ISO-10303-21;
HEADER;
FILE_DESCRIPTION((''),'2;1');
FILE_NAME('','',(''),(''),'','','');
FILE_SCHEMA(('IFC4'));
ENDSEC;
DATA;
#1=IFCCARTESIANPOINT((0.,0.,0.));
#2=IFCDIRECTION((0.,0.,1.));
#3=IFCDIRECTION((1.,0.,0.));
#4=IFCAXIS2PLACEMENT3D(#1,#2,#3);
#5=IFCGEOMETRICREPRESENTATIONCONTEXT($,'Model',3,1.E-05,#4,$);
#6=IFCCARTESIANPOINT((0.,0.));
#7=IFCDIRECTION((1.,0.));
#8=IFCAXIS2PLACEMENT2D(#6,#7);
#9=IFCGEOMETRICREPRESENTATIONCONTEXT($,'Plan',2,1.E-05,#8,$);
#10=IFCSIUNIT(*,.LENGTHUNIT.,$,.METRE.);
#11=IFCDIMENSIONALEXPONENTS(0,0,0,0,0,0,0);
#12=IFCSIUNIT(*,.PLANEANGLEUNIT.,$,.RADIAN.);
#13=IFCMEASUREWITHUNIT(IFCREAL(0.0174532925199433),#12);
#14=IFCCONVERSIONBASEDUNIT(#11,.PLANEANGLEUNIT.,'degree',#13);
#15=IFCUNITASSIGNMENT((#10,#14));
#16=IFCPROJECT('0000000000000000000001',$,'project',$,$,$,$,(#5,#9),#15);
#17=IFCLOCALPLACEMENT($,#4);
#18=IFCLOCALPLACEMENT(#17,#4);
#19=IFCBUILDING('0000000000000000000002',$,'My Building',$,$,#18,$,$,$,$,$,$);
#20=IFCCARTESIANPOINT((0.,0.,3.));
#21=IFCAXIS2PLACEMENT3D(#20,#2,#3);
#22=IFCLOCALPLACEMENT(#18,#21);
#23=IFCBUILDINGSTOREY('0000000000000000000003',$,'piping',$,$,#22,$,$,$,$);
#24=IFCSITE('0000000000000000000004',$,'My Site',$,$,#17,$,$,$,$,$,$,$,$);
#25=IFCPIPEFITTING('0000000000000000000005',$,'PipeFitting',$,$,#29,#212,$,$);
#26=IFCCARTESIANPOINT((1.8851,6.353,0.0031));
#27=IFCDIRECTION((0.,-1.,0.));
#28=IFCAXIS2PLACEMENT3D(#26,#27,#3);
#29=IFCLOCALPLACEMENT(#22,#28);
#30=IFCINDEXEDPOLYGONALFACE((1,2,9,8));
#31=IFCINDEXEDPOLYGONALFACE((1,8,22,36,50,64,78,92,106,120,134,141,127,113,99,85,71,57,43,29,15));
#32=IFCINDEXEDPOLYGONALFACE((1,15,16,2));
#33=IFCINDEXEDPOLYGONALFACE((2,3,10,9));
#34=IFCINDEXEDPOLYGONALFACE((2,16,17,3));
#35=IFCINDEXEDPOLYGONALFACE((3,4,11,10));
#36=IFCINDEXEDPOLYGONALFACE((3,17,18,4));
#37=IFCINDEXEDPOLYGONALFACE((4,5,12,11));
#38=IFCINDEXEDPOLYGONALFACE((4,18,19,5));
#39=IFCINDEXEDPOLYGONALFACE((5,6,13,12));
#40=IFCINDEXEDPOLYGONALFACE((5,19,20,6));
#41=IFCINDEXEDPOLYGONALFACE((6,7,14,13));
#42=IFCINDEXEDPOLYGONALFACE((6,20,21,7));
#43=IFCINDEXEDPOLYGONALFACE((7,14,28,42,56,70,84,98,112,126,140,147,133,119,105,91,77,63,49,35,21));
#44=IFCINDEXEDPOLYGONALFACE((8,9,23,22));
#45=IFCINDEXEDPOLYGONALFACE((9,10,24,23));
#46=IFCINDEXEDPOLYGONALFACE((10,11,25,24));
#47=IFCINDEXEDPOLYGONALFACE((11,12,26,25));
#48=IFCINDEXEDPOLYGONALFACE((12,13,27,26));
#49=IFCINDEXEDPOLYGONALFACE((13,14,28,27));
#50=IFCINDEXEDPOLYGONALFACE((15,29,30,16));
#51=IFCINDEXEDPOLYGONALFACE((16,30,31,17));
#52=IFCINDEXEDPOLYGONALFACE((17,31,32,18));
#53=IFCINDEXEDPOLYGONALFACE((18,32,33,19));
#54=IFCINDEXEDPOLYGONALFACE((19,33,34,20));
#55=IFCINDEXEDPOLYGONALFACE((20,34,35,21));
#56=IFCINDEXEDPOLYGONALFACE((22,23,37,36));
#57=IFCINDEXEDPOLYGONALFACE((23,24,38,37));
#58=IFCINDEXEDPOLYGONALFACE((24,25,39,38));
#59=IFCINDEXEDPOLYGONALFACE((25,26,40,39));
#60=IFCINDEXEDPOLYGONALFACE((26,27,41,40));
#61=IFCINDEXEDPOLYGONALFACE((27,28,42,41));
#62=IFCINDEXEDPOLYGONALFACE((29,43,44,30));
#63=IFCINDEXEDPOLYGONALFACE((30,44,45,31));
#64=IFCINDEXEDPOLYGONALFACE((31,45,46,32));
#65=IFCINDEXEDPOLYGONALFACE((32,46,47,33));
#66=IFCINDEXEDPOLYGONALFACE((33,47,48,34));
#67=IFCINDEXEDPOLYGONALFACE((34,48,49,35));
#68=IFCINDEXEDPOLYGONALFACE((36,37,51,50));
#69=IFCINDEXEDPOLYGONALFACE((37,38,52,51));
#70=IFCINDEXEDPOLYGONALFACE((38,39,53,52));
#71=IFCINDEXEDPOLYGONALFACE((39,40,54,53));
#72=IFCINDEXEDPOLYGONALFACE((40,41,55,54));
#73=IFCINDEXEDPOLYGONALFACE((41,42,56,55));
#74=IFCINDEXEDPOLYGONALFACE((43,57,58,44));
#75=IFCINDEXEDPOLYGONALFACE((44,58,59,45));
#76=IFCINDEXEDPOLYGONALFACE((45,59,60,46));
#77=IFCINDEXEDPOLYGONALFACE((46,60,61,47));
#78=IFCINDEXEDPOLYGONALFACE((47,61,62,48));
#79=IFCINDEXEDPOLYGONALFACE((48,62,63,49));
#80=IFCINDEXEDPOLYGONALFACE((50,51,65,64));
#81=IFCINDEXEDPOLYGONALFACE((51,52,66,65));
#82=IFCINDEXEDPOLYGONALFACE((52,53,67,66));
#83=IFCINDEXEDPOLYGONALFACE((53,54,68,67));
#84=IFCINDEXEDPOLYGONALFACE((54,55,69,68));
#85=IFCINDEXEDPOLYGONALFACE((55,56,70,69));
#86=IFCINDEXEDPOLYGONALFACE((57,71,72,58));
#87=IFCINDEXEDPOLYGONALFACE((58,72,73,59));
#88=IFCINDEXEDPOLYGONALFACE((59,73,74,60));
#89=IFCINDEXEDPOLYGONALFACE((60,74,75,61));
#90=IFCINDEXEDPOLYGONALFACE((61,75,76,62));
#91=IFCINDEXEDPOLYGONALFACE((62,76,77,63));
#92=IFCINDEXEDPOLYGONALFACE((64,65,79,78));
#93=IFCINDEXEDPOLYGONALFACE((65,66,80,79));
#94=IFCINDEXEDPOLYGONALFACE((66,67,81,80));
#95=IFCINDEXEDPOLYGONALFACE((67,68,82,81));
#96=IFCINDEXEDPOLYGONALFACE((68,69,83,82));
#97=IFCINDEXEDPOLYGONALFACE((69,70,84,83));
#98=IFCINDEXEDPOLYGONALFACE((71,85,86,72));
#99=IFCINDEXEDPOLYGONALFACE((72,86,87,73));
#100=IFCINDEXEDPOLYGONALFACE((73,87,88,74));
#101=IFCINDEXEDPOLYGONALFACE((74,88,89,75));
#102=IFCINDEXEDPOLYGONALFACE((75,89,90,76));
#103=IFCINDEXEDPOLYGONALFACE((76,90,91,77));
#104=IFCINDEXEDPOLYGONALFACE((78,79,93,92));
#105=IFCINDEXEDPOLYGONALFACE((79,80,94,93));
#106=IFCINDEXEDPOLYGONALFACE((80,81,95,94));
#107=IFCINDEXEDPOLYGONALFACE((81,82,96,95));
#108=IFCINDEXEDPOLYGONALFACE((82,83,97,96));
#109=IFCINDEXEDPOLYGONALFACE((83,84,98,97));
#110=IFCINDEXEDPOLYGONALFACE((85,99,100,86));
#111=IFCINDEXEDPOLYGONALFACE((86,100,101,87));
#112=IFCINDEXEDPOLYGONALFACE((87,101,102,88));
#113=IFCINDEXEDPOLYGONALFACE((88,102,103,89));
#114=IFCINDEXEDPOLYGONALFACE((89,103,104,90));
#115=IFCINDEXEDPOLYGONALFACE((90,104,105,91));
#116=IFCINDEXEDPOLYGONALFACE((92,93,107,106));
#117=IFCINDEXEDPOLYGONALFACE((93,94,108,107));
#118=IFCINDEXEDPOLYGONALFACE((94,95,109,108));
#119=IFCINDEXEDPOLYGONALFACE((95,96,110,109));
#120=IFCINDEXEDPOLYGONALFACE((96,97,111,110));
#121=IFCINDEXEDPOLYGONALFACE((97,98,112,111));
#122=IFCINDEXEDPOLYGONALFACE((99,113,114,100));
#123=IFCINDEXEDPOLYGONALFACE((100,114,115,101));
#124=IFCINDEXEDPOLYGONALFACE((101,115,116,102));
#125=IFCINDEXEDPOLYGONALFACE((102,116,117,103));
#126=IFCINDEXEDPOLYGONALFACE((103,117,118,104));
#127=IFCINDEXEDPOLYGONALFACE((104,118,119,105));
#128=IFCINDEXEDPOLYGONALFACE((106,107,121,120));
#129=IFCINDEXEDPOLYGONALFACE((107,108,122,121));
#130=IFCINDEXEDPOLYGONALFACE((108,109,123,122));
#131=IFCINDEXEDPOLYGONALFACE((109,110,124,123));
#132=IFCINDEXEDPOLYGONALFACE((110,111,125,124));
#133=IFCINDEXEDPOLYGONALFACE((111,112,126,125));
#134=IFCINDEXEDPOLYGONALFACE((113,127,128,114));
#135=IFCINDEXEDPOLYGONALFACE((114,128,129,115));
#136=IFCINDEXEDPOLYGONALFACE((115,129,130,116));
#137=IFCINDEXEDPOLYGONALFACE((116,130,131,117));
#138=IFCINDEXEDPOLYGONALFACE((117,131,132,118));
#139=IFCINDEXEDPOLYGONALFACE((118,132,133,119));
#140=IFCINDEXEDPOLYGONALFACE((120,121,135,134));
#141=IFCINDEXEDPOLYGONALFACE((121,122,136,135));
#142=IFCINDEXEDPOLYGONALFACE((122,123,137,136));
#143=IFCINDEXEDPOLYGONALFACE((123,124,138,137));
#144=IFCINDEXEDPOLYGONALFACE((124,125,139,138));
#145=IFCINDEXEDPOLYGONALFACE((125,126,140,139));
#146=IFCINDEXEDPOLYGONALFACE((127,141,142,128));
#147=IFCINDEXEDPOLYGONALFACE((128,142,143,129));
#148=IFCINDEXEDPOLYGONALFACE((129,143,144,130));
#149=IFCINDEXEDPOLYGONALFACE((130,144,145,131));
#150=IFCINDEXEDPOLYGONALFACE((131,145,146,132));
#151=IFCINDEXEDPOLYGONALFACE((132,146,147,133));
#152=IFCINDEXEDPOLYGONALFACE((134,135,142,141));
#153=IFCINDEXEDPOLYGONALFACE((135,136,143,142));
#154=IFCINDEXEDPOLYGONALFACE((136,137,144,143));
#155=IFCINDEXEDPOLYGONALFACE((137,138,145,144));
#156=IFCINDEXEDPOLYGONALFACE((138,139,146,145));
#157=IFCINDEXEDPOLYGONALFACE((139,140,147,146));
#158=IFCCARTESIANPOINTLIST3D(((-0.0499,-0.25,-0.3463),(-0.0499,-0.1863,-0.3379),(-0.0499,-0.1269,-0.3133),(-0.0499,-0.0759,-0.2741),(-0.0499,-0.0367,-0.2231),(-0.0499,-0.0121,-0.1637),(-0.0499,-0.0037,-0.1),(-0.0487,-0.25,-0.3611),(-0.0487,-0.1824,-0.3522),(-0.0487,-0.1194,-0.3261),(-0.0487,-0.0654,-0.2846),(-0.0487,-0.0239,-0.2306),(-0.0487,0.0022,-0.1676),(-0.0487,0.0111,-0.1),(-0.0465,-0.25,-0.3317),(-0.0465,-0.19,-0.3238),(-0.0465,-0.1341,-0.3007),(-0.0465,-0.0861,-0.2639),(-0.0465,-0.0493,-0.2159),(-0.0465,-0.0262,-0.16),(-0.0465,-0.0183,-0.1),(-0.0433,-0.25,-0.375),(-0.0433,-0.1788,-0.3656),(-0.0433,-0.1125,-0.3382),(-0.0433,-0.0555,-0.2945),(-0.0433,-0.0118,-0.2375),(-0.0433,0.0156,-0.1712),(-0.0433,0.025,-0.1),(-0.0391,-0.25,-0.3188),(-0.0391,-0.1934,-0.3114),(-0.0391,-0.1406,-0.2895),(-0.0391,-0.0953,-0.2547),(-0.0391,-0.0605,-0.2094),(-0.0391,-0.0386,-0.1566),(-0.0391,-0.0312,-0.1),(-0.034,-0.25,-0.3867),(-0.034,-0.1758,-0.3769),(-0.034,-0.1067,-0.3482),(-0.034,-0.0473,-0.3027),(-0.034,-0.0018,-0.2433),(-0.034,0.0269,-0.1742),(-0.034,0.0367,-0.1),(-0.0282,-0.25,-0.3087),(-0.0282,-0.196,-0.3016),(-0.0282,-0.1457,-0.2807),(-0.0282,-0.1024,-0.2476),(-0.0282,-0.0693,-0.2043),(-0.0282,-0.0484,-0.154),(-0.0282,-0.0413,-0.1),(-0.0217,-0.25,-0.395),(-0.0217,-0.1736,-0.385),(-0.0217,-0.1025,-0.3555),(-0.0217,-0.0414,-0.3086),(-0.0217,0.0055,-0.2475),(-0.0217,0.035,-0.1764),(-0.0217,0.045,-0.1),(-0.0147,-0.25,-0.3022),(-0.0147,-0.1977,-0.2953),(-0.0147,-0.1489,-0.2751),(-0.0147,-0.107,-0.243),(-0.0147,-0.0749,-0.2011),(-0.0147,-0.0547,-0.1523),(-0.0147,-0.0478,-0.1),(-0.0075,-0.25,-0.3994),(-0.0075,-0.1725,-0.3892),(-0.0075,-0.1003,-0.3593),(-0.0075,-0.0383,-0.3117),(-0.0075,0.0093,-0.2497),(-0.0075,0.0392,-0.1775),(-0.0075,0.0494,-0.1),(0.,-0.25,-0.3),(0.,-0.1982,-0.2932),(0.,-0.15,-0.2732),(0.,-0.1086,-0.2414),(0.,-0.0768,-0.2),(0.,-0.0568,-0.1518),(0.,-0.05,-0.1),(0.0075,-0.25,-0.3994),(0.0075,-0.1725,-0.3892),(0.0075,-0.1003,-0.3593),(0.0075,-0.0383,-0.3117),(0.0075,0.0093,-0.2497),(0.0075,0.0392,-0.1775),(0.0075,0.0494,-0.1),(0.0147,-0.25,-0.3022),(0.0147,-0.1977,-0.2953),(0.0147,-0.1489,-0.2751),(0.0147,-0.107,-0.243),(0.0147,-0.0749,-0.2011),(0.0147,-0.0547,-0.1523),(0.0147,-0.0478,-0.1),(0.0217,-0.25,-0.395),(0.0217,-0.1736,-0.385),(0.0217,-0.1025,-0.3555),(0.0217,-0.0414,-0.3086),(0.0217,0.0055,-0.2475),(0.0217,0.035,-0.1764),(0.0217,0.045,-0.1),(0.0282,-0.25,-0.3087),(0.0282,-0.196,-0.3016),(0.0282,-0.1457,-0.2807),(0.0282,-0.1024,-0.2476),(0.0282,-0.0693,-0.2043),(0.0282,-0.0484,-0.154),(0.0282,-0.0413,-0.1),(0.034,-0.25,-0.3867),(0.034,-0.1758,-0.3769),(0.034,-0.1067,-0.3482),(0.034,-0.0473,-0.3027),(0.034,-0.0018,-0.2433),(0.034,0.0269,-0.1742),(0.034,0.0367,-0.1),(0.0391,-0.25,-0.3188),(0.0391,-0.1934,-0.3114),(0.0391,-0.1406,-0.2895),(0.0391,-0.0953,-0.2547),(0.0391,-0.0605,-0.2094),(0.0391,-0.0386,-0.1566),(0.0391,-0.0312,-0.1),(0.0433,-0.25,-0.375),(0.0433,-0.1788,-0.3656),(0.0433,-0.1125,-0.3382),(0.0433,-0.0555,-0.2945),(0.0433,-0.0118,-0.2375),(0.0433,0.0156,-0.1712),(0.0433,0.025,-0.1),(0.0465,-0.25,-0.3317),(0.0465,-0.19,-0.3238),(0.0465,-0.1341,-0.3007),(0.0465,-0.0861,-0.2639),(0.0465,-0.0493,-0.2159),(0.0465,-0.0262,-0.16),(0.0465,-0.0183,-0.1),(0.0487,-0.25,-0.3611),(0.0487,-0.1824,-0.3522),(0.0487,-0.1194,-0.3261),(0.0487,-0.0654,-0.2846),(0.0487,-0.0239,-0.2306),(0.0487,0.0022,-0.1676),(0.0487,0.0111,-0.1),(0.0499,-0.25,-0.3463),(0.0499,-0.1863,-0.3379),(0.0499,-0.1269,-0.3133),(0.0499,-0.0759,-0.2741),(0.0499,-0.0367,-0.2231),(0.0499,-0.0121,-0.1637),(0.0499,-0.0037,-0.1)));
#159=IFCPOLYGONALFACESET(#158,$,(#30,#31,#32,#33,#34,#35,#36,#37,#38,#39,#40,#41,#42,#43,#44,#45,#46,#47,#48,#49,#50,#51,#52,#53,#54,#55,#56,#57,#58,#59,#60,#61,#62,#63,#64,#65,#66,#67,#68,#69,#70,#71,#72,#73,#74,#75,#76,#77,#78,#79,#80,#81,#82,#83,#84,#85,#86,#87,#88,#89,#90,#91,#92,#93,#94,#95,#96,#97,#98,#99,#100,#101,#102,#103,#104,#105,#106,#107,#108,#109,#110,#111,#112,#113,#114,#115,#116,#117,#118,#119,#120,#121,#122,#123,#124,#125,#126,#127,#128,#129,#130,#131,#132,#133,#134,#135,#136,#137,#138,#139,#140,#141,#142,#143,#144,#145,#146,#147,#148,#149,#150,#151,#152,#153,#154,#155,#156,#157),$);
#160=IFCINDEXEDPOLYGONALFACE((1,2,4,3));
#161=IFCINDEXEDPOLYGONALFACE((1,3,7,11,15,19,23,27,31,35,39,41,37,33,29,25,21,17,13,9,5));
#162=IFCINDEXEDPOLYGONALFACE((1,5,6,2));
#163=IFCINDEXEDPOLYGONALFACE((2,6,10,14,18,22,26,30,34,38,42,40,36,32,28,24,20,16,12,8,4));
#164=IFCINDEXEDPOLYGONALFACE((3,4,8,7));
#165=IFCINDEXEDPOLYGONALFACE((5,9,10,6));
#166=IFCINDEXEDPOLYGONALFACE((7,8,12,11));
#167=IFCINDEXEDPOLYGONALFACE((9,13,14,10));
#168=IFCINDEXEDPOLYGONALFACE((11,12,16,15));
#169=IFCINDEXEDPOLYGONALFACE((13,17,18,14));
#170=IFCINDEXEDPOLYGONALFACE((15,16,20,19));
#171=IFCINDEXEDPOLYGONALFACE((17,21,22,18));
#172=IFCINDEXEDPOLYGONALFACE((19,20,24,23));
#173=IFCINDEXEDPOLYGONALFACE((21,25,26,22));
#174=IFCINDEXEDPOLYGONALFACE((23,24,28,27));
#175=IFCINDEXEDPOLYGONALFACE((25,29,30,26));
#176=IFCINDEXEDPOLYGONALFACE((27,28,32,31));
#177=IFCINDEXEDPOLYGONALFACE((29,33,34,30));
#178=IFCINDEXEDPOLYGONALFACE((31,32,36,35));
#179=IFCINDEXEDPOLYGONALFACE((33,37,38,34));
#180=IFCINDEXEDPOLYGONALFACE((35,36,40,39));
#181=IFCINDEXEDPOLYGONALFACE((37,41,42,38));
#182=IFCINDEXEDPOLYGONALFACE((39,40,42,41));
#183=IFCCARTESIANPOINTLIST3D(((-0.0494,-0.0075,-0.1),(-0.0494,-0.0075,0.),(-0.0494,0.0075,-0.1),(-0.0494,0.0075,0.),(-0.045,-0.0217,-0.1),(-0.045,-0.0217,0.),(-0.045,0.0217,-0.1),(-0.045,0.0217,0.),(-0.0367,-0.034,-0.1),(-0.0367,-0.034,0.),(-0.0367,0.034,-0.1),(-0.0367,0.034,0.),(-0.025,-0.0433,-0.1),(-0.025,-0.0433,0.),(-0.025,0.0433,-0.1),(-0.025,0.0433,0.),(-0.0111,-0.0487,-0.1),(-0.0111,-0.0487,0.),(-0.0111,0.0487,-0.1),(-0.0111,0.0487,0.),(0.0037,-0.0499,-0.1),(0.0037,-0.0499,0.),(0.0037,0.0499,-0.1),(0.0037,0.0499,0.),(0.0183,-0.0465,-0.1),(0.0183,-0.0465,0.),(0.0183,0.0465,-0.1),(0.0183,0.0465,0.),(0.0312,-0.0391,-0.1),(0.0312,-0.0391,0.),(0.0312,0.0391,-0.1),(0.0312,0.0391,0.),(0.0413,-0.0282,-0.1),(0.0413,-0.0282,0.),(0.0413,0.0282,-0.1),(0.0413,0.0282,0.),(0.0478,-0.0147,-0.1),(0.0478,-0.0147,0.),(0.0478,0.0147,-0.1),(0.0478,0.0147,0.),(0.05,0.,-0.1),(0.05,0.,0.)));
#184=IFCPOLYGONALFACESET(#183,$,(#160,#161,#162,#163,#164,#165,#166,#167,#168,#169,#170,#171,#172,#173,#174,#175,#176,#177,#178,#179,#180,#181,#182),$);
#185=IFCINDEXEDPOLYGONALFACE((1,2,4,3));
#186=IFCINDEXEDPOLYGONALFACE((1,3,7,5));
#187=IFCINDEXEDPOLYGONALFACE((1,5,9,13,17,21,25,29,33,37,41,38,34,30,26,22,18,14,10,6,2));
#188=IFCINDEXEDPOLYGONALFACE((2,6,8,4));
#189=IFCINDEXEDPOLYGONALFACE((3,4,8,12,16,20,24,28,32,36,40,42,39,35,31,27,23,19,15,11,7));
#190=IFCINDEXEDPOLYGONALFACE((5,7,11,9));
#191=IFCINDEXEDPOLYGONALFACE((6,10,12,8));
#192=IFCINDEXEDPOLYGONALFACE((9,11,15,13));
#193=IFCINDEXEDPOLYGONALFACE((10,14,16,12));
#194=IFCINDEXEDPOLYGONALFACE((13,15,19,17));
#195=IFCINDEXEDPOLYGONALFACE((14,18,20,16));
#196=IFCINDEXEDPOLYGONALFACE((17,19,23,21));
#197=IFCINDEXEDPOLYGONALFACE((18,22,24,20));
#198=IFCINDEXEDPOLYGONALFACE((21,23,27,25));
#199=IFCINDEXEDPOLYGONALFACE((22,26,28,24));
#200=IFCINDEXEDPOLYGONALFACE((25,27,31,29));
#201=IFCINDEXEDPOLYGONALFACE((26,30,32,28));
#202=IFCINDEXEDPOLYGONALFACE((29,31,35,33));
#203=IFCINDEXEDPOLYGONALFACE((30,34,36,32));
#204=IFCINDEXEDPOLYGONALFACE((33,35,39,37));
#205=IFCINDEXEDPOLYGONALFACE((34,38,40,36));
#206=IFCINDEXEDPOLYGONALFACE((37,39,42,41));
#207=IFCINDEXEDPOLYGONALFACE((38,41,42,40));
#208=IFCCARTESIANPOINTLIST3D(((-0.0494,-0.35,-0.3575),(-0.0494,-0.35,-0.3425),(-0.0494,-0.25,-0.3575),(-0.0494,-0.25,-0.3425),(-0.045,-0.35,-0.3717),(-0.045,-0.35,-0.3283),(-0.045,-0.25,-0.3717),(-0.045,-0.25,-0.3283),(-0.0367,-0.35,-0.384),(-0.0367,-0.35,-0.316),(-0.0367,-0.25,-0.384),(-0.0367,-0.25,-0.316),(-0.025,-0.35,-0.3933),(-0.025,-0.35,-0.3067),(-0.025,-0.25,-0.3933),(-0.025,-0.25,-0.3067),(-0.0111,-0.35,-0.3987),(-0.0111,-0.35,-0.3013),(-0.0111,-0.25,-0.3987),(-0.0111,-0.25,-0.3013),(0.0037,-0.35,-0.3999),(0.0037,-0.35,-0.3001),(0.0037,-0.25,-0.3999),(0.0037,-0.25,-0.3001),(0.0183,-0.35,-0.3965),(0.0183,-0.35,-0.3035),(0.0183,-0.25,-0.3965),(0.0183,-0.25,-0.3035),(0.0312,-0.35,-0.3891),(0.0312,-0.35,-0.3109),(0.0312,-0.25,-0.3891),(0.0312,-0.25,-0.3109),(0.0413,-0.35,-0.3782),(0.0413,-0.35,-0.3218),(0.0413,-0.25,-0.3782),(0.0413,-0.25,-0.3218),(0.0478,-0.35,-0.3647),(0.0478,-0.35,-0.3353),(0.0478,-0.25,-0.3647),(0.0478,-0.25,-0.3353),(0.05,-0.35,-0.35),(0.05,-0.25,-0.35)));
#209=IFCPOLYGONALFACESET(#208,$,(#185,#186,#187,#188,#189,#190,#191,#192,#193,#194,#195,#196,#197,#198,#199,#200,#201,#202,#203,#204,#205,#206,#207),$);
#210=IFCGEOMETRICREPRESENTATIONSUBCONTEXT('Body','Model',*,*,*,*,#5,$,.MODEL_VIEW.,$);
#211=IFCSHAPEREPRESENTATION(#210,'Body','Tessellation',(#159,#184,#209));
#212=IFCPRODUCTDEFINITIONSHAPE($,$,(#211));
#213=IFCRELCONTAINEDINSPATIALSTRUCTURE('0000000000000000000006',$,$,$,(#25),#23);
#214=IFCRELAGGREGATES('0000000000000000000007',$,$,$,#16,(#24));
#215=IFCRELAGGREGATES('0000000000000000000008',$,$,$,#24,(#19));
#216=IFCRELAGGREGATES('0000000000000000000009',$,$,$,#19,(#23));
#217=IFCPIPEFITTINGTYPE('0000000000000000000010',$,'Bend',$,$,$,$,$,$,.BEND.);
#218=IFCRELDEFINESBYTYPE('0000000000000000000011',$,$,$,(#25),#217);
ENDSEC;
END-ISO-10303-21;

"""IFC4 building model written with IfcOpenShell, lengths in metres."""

from ifc_helpers import new_model, entity, si_unit, converted_unit, frame, origin_with_axes, origin_2d_with_axis, place, context, subcontext, project, spatial, circle, extrude, source, transform, mapped, type_object, type_shapes, element, save


model = new_model("IFC4")

# Units and contexts
model_context = context("Model", 3, precision=1e-05, world=origin_with_axes())
plan_context = context("Plan", 2, precision=1e-05, world=origin_2d_with_axis())
body_context = subcontext(model_context, "Body", "Model", "MODEL_VIEW")
ifc_project = project(units=[si_unit("LENGTHUNIT", "METRE"), converted_unit("PLANEANGLEUNIT", "degree", entity("IfcReal", 0.0174532925199433), si_unit("PLANEANGLEUNIT", "RADIAN"), dimensions=[0, 0, 0, 0, 0, 0, 0])], contexts=[model_context, plan_context])

# Site, building, storey
site_placement = place(None, origin_with_axes())
site = spatial("IfcSite", under=ifc_project, at=site_placement, Name="My Site")
building_placement = place(site_placement, origin_with_axes())
building = spatial("IfcBuilding", under=site, at=building_placement, Name="My Building")
storey_placement = place(building_placement, frame((0.0, 0.0, 3.0), z_axis=(0.0, 0.0, 1.0), x_axis=(1.0, 0.0, 0.0)))
storey = spatial("IfcBuildingStorey", under=building, at=storey_placement, Name="piping")

# Pipe fitting
pipe_fitting_type = type_object("IfcPipeFittingType", Name="Bend", PredefinedType="BEND")
shared_shape = source(origin_with_axes(), body_context, "Body", "SolidModel", [
    entity("IfcSweptDiskSolid", entity("IfcIndexedPolyCurve", entity("IfcCartesianPointList3D", [[0.0, 0.0, -0.1], [0.0, -0.0732, -0.2768], [0.0, -0.25, -0.35]]), [entity("IfcArcIndex", [1, 2, 3])]), 0.05),
    extrude(circle(Radius=0.05), origin_with_axes(), (0.0, 0.0, -1.0), 0.1),
    extrude(circle(Radius=0.05), frame((0.0, -0.25, -0.35), z_axis=(0.0, -1.0, 0.0), x_axis=(1.0, 0.0, 0.0)), (0.0, 0.0, 1.0), 0.1),
])
type_shapes(pipe_fitting_type, [shared_shape])
for number, where, z_axis, x_axis, name in (
    (1, (1.8851, 6.353, 0.0031), (0.0, -1.0, 0.0), (1.0, 0.0, 0.0), "PipeFitting"),
):
    element("IfcPipeFitting", number, at=place(storey_placement, frame(where, z_axis=z_axis, x_axis=x_axis)), inside=storey, type_object=pipe_fitting_type, Name=name, context=body_context, shape_type="MappedRepresentation", body=[
        mapped(shared_shape, transform((0.0, 0.0, 0.0), x_axis=(1.0, 0.0, 0.0), y_axis=(0.0, 1.0, 0.0), z_axis=(0.0, 0.0, 1.0), scale=1.0)),
    ])

save(model, "model.ifc")
